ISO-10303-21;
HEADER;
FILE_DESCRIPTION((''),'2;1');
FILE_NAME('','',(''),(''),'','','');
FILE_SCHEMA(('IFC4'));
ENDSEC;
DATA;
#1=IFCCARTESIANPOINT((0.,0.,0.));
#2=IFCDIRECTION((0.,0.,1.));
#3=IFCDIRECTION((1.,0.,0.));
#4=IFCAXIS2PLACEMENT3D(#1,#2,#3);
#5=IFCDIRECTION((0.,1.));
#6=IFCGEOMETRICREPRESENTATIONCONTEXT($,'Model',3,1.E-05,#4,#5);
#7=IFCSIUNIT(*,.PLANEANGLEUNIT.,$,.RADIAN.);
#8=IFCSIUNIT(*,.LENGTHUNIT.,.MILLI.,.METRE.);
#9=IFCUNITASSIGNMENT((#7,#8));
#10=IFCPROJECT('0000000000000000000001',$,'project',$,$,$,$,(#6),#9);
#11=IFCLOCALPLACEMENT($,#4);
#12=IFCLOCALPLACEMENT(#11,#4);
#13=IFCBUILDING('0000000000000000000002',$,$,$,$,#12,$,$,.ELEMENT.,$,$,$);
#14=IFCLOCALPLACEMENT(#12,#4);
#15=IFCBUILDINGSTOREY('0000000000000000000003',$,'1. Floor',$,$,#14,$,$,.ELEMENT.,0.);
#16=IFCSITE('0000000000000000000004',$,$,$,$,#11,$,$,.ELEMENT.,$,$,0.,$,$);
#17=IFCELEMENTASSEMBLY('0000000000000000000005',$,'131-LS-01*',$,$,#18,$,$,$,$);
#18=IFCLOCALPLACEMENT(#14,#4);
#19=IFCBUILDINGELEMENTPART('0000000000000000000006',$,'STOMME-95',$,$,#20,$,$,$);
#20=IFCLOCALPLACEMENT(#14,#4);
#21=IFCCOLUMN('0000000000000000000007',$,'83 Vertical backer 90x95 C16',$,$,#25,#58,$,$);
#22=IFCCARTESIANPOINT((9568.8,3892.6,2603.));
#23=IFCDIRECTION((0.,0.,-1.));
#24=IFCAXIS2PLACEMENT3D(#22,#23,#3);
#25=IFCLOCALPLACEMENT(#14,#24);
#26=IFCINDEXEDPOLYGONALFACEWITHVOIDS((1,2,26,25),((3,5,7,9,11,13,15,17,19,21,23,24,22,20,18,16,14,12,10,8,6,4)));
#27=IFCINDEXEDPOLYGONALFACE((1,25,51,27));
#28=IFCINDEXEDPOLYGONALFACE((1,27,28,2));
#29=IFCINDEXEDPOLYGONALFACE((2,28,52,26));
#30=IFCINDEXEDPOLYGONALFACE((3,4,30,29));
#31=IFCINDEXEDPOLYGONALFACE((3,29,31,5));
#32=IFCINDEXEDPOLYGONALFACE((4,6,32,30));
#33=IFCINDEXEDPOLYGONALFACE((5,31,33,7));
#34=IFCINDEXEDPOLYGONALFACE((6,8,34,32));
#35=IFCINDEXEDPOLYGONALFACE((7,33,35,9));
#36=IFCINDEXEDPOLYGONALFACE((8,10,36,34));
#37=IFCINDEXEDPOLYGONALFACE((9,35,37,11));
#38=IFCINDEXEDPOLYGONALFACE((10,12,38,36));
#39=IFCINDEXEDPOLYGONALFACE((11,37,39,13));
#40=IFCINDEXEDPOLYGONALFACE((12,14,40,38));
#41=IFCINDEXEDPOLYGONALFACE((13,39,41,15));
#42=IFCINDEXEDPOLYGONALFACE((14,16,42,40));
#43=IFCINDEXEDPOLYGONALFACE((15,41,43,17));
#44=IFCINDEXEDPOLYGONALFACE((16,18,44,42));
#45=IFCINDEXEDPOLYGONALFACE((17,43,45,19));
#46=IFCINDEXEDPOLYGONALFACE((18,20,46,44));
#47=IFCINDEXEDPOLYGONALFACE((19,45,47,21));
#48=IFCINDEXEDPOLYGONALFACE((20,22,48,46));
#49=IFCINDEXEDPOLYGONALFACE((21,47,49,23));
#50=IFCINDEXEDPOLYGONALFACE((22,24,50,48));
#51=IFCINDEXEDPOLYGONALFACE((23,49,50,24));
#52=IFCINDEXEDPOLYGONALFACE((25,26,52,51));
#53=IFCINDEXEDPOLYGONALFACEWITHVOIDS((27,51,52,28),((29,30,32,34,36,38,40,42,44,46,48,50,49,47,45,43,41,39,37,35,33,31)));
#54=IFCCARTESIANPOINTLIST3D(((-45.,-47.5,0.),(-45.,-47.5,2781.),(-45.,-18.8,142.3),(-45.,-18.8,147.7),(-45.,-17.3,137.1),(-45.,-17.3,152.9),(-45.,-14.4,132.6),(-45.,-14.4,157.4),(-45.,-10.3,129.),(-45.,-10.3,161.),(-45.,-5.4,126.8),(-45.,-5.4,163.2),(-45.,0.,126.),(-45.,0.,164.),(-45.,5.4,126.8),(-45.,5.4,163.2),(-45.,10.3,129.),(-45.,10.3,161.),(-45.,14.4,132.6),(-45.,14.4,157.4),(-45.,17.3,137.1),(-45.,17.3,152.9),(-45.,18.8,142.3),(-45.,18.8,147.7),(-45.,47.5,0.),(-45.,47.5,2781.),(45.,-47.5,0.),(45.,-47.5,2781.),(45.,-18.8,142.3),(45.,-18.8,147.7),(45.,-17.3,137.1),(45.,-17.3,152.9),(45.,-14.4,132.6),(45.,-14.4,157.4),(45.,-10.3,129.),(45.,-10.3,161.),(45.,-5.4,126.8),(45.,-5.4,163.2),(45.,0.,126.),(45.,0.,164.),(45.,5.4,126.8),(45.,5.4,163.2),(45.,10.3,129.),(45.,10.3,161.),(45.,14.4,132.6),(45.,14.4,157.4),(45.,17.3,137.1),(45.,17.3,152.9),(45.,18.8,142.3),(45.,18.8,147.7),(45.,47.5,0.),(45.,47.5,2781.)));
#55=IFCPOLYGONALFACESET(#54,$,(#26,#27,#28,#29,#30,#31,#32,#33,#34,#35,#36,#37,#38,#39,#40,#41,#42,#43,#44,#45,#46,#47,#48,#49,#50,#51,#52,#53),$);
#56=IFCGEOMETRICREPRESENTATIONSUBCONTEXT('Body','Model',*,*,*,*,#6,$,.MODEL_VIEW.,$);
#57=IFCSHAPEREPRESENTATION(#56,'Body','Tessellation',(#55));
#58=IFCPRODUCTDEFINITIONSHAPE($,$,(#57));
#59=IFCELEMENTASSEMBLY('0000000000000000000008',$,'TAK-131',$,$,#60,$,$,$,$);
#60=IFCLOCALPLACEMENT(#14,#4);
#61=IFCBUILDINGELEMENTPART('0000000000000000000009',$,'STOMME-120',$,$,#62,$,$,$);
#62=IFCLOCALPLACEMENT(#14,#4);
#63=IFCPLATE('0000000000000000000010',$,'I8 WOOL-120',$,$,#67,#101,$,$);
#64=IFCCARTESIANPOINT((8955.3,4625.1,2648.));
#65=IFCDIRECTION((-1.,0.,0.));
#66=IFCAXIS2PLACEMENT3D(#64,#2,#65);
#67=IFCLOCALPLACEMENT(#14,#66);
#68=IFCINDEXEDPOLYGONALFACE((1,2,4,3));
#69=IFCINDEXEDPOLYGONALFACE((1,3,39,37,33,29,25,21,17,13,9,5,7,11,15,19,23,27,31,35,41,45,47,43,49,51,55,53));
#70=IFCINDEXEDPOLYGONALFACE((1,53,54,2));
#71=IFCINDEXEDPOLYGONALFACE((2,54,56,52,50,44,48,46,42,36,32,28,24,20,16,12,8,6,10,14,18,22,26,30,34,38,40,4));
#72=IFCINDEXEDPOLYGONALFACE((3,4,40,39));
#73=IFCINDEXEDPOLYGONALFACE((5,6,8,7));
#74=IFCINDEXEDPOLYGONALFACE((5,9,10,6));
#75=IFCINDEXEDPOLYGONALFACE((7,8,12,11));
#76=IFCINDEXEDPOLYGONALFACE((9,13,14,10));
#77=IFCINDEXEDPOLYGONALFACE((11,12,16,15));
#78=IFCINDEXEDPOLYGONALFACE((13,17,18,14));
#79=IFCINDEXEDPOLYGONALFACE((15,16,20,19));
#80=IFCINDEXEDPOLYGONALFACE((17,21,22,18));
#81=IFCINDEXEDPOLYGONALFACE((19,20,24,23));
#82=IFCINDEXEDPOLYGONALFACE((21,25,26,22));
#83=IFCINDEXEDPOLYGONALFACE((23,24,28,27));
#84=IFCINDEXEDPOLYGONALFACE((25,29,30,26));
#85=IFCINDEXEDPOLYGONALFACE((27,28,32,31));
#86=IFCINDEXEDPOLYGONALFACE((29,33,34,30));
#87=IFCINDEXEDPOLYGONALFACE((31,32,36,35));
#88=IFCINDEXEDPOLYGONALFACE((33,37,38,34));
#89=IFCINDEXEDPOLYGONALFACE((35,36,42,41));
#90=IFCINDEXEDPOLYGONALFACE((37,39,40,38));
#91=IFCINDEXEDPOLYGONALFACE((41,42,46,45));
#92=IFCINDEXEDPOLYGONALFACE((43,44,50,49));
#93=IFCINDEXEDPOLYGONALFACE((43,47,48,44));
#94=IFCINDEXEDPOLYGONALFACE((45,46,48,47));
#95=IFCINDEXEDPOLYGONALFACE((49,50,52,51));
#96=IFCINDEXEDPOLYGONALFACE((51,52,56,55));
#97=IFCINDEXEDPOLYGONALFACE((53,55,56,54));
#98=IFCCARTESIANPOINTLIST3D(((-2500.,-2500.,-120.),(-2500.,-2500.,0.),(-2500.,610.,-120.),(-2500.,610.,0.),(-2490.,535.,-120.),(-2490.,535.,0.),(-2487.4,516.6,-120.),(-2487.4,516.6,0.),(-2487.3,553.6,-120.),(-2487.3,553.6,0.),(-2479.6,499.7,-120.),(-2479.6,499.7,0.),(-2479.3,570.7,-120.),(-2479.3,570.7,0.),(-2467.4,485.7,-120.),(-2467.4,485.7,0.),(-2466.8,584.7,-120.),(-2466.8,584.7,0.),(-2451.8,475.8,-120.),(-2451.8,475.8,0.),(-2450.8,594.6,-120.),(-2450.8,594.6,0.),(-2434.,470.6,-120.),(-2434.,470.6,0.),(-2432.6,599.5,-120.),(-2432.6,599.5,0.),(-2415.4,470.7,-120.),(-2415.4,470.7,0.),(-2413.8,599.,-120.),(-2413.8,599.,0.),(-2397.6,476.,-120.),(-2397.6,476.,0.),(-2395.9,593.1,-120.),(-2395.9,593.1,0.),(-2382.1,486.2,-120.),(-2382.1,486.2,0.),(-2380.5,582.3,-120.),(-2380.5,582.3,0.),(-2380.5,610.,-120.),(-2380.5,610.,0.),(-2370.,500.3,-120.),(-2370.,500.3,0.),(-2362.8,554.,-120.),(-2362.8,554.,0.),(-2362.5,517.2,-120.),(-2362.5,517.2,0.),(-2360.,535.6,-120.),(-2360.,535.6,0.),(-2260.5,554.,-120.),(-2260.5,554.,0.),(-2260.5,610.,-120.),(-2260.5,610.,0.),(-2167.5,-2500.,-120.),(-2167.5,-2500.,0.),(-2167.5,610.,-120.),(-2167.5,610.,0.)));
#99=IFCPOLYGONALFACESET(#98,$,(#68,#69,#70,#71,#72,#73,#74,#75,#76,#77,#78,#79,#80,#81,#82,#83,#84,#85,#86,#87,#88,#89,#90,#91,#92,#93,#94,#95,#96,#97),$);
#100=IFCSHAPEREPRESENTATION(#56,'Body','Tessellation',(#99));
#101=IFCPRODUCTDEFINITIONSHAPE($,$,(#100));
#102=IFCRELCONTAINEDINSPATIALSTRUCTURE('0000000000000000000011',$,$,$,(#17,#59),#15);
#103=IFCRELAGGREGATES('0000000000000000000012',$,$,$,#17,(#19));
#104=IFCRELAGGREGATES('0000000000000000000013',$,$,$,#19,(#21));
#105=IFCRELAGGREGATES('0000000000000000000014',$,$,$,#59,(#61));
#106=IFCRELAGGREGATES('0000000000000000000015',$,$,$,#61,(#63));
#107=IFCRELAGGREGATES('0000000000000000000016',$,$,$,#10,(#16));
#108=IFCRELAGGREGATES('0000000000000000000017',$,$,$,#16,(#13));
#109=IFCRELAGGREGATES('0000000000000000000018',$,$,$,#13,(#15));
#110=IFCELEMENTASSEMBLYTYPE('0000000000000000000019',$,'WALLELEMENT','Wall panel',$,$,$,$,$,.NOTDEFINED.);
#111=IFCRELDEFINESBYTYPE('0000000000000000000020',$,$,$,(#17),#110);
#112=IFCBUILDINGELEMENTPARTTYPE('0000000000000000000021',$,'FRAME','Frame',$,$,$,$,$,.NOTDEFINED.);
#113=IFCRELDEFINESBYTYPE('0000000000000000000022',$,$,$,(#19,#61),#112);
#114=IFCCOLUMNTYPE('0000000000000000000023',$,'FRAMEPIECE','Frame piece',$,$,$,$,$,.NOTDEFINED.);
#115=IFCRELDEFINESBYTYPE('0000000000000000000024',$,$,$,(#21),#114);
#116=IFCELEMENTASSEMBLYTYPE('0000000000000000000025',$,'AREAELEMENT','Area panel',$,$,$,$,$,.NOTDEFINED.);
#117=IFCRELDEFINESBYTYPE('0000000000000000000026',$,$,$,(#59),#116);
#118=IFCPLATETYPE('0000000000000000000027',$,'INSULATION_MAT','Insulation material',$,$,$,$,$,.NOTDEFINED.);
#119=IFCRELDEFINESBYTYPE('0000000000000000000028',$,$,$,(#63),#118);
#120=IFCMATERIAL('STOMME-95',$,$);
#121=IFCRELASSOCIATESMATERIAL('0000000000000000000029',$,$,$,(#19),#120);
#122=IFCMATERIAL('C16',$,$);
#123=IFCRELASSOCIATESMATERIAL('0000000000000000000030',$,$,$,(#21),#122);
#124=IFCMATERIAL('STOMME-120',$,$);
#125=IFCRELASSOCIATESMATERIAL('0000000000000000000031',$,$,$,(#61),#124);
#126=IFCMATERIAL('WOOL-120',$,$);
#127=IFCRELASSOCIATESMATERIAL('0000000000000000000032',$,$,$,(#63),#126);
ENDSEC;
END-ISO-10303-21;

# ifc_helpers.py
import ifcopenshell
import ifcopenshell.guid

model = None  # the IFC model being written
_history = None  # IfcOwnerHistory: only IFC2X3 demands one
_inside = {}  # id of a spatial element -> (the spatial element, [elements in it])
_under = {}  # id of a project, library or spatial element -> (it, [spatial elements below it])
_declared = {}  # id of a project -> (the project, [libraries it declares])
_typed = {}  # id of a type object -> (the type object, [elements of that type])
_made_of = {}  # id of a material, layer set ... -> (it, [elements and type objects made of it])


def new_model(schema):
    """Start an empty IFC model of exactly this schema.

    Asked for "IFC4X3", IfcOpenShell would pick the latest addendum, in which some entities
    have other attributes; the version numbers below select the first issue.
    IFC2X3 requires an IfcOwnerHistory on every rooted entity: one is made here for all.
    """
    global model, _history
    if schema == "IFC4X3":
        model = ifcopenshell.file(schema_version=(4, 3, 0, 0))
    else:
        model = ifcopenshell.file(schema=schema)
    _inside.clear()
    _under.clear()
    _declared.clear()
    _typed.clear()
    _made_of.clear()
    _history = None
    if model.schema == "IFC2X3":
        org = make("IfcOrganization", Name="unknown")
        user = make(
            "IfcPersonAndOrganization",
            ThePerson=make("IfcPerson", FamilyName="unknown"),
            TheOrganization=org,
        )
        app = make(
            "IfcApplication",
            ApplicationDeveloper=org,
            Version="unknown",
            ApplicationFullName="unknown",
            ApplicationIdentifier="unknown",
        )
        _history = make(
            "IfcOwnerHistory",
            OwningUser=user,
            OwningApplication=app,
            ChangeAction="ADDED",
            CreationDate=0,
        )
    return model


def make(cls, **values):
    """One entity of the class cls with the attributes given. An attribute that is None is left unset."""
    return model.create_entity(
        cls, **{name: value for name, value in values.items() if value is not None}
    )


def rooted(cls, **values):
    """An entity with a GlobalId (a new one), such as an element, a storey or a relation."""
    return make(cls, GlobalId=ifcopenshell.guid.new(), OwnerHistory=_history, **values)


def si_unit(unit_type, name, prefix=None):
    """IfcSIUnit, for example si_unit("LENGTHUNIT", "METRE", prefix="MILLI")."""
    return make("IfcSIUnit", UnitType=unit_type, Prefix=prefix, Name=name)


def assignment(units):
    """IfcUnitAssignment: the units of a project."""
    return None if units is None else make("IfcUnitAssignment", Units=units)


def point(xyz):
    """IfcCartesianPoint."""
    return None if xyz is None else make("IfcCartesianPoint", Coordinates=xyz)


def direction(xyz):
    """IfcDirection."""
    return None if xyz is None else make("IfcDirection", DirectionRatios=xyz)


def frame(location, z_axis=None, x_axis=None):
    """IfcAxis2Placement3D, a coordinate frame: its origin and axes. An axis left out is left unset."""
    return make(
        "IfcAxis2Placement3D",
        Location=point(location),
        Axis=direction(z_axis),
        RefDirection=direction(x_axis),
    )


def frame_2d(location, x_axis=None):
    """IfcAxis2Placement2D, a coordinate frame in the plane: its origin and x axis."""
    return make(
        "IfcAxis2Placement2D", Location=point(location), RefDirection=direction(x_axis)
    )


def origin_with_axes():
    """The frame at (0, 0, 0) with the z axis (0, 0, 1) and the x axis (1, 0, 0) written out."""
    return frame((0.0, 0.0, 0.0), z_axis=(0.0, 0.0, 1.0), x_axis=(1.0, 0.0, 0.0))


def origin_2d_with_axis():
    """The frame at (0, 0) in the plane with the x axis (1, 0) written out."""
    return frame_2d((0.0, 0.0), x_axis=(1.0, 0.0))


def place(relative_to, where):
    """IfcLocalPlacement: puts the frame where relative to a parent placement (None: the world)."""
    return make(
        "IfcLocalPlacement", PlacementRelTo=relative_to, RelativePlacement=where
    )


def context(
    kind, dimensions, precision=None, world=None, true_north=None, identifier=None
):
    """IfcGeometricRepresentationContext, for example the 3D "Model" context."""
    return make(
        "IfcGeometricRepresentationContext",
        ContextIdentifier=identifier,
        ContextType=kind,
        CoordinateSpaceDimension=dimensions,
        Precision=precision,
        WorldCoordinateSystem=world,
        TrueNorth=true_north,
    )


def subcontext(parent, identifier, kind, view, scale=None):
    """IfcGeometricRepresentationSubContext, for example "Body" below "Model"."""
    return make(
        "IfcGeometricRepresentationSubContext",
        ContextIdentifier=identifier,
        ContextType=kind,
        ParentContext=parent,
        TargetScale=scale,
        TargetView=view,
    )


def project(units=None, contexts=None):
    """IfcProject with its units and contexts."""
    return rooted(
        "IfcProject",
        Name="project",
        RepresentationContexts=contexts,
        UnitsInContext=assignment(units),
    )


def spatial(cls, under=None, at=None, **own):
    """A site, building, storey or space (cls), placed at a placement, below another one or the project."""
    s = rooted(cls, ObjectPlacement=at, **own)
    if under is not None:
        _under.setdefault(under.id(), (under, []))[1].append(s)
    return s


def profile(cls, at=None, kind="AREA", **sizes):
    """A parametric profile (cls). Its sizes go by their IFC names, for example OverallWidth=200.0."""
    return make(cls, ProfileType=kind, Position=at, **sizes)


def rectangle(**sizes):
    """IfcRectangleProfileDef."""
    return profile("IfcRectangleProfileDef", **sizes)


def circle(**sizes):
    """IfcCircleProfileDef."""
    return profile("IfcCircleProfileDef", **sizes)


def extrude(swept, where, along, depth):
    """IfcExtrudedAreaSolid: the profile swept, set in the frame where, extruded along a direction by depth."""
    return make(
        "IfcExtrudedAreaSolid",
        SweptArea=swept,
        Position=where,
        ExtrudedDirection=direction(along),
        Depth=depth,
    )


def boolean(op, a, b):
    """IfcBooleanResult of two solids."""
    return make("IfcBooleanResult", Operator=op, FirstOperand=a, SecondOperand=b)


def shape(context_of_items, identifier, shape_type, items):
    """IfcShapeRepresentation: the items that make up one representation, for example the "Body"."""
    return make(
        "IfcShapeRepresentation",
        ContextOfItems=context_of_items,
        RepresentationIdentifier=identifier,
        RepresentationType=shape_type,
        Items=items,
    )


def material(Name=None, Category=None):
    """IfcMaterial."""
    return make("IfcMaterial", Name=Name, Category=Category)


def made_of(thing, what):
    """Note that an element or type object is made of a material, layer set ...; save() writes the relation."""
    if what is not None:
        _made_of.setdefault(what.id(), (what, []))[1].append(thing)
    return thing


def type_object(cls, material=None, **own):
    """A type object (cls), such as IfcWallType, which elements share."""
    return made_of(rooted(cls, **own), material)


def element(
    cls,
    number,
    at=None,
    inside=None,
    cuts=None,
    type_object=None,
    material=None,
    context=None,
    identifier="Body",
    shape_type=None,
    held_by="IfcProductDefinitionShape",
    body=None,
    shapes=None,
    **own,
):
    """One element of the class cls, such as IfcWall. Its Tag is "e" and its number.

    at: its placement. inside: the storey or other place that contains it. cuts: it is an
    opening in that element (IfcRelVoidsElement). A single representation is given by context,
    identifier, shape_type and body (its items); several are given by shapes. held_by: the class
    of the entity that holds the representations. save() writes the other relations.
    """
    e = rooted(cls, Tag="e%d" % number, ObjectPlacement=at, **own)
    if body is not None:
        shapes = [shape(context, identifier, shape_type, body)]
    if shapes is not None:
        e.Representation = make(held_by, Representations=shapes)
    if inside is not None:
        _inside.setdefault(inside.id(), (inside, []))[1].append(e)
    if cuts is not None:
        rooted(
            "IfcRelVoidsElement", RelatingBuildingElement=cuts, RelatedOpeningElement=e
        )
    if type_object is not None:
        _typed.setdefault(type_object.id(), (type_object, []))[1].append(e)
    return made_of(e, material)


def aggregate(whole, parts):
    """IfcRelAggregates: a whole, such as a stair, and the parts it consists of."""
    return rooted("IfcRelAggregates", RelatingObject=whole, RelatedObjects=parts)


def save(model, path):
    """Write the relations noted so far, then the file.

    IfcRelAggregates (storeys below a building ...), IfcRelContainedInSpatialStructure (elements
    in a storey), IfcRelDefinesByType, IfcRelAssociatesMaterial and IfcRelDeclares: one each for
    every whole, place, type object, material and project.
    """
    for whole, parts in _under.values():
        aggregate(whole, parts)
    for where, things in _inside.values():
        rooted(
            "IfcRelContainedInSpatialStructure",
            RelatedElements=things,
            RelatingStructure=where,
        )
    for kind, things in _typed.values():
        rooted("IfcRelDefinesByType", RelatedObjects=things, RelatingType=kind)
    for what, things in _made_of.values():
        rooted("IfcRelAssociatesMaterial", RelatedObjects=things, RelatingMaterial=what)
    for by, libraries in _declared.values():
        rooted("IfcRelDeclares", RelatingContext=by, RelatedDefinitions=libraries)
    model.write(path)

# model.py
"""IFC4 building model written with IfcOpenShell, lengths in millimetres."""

from ifc_helpers import new_model, si_unit, direction, frame, origin_with_axes, origin_2d_with_axis, place, context, subcontext, project, spatial, rectangle, circle, extrude, boolean, material, type_object, element, aggregate, save


model = new_model("IFC4")

# Units and contexts
model_context = context("Model", 3, precision=1e-05, world=origin_with_axes(), true_north=direction((0.0, 1.0)))
body_context = subcontext(model_context, "Body", "Model", "MODEL_VIEW")
ifc_project = project(units=[si_unit("PLANEANGLEUNIT", "RADIAN"), si_unit("LENGTHUNIT", "METRE", prefix="MILLI")], contexts=[model_context])

# Site, building, storey
site_placement = place(None, origin_with_axes())
site = spatial("IfcSite", under=ifc_project, at=site_placement, CompositionType="ELEMENT", RefElevation=0.0)
building_placement = place(site_placement, origin_with_axes())
building = spatial("IfcBuilding", under=site, at=building_placement, CompositionType="ELEMENT")
storey_placement = place(building_placement, origin_with_axes())
storey = spatial("IfcBuildingStorey", under=building, at=storey_placement, Name="1. Floor", CompositionType="ELEMENT", Elevation=0.0)

# Shared definitions
element_assembly_type_1 = type_object("IfcElementAssemblyType", Name="WALLELEMENT", Description="Wall panel", PredefinedType="NOTDEFINED")
ifc_material_1 = material(Name="STOMME-95")
building_element_part_type = type_object("IfcBuildingElementPartType", Name="FRAME", Description="Frame", PredefinedType="NOTDEFINED")
ifc_material_2 = material(Name="C16")
column_type = type_object("IfcColumnType", Name="FRAMEPIECE", Description="Frame piece", PredefinedType="NOTDEFINED")

# Element assembly, building element part, column
assembly_1_placement = place(storey_placement, origin_with_axes())
assembly_1 = element("IfcElementAssembly", 1, at=assembly_1_placement, inside=storey, type_object=element_assembly_type_1, Name="131-LS-01*")
building_element_part_1_placement = place(storey_placement, origin_with_axes())
building_element_part_1 = element("IfcBuildingElementPart", 2, at=building_element_part_1_placement, type_object=building_element_part_type, material=ifc_material_1, Name="STOMME-95")
aggregate(assembly_1, [building_element_part_1])
column_1_placement = place(storey_placement, frame((9568.8, 3892.6, 2603.0), z_axis=(0.0, 0.0, -1.0), x_axis=(1.0, 0.0, 0.0)))
column_1 = element("IfcColumn", 3, at=column_1_placement, type_object=column_type, material=ifc_material_2, Name="83 Vertical backer 90x95 C16", context=body_context, shape_type="CSG", body=[
    boolean("DIFFERENCE", boolean("DIFFERENCE", extrude(rectangle(XDim=90.0, YDim=95.0, at=origin_2d_with_axis()), origin_with_axes(), (0.0, 0.0, 1.0), 2781.0), extrude(circle(Radius=19.0, at=origin_2d_with_axis()), frame((90.0, 0.0, 145.0), z_axis=(1.0, 0.0, 0.0), x_axis=(0.0, 0.0, -1.0)), (0.0, 0.0, -1.0), 180.0)), extrude(circle(Radius=19.0, at=origin_2d_with_axis()), frame((-90.0, 0.0, 145.0), z_axis=(-1.0, 0.0, 0.0), x_axis=(0.0, 0.0, 1.0)), (0.0, 0.0, -1.0), 180.0)),
])
aggregate(building_element_part_1, [column_1])

# Element assembly, building element part, plate
element_assembly_type_2 = type_object("IfcElementAssemblyType", Name="AREAELEMENT", Description="Area panel", PredefinedType="NOTDEFINED")
assembly_2_placement = place(storey_placement, origin_with_axes())
assembly_2 = element("IfcElementAssembly", 4, at=assembly_2_placement, inside=storey, type_object=element_assembly_type_2, Name="TAK-131")
ifc_material_3 = material(Name="STOMME-120")
building_element_part_2_placement = place(storey_placement, origin_with_axes())
building_element_part_2 = element("IfcBuildingElementPart", 5, at=building_element_part_2_placement, type_object=building_element_part_type, material=ifc_material_3, Name="STOMME-120")
aggregate(assembly_2, [building_element_part_2])
ifc_material_4 = material(Name="WOOL-120")
plate_type = type_object("IfcPlateType", Name="INSULATION_MAT", Description="Insulation material", PredefinedType="NOTDEFINED")
plate_1_placement = place(storey_placement, frame((8955.3, 4625.1, 2648.0), z_axis=(0.0, 0.0, 1.0), x_axis=(-1.0, 0.0, 0.0)))
plate_1 = element("IfcPlate", 6, at=plate_1_placement, type_object=plate_type, material=ifc_material_4, Name="I8 WOOL-120", context=body_context, shape_type="CSG", body=[
    boolean("DIFFERENCE", boolean("DIFFERENCE", boolean("DIFFERENCE", boolean("DIFFERENCE", extrude(rectangle(XDim=120.0, YDim=332.5, at=origin_2d_with_axis()), frame((-2333.7, -2500.0, -60.0), z_axis=(0.0, 1.0, 0.0), x_axis=(0.0, 0.0, 1.0)), (0.0, 0.0, 1.0), 3110.0), extrude(circle(Radius=65.0, at=origin_2d_with_axis()), frame((-2425.0, 535.0, 0.0), z_axis=(0.0, 0.0, 1.0), x_axis=(-1.0, 0.0, 0.0)), (0.0, 0.0, -1.0), 200.0)), extrude(rectangle(XDim=100.0, YDim=120.0, at=origin_2d_with_axis()), frame((-2320.5, 604.0, 0.0), z_axis=(0.0, 0.0, 1.0), x_axis=(0.0, -1.0, 0.0)), (0.0, 0.0, -1.0), 120.0)), extrude(rectangle(XDim=100.0, YDim=120.0, at=origin_2d_with_axis()), frame((-2320.5, 604.0, 0.0), z_axis=(0.0, 0.0, 1.0), x_axis=(0.0, -1.0, 0.0)), (0.0, 0.0, -1.0), 150.0)), extrude(circle(Radius=65.0, at=origin_2d_with_axis()), frame((-2425.0, 535.0, 0.0), z_axis=(0.0, 0.0, 1.0), x_axis=(-1.0, 0.0, 0.0)), (0.0, 0.0, -1.0), 200.0)),
])
aggregate(building_element_part_2, [plate_1])

save(model, "model.ifc")
